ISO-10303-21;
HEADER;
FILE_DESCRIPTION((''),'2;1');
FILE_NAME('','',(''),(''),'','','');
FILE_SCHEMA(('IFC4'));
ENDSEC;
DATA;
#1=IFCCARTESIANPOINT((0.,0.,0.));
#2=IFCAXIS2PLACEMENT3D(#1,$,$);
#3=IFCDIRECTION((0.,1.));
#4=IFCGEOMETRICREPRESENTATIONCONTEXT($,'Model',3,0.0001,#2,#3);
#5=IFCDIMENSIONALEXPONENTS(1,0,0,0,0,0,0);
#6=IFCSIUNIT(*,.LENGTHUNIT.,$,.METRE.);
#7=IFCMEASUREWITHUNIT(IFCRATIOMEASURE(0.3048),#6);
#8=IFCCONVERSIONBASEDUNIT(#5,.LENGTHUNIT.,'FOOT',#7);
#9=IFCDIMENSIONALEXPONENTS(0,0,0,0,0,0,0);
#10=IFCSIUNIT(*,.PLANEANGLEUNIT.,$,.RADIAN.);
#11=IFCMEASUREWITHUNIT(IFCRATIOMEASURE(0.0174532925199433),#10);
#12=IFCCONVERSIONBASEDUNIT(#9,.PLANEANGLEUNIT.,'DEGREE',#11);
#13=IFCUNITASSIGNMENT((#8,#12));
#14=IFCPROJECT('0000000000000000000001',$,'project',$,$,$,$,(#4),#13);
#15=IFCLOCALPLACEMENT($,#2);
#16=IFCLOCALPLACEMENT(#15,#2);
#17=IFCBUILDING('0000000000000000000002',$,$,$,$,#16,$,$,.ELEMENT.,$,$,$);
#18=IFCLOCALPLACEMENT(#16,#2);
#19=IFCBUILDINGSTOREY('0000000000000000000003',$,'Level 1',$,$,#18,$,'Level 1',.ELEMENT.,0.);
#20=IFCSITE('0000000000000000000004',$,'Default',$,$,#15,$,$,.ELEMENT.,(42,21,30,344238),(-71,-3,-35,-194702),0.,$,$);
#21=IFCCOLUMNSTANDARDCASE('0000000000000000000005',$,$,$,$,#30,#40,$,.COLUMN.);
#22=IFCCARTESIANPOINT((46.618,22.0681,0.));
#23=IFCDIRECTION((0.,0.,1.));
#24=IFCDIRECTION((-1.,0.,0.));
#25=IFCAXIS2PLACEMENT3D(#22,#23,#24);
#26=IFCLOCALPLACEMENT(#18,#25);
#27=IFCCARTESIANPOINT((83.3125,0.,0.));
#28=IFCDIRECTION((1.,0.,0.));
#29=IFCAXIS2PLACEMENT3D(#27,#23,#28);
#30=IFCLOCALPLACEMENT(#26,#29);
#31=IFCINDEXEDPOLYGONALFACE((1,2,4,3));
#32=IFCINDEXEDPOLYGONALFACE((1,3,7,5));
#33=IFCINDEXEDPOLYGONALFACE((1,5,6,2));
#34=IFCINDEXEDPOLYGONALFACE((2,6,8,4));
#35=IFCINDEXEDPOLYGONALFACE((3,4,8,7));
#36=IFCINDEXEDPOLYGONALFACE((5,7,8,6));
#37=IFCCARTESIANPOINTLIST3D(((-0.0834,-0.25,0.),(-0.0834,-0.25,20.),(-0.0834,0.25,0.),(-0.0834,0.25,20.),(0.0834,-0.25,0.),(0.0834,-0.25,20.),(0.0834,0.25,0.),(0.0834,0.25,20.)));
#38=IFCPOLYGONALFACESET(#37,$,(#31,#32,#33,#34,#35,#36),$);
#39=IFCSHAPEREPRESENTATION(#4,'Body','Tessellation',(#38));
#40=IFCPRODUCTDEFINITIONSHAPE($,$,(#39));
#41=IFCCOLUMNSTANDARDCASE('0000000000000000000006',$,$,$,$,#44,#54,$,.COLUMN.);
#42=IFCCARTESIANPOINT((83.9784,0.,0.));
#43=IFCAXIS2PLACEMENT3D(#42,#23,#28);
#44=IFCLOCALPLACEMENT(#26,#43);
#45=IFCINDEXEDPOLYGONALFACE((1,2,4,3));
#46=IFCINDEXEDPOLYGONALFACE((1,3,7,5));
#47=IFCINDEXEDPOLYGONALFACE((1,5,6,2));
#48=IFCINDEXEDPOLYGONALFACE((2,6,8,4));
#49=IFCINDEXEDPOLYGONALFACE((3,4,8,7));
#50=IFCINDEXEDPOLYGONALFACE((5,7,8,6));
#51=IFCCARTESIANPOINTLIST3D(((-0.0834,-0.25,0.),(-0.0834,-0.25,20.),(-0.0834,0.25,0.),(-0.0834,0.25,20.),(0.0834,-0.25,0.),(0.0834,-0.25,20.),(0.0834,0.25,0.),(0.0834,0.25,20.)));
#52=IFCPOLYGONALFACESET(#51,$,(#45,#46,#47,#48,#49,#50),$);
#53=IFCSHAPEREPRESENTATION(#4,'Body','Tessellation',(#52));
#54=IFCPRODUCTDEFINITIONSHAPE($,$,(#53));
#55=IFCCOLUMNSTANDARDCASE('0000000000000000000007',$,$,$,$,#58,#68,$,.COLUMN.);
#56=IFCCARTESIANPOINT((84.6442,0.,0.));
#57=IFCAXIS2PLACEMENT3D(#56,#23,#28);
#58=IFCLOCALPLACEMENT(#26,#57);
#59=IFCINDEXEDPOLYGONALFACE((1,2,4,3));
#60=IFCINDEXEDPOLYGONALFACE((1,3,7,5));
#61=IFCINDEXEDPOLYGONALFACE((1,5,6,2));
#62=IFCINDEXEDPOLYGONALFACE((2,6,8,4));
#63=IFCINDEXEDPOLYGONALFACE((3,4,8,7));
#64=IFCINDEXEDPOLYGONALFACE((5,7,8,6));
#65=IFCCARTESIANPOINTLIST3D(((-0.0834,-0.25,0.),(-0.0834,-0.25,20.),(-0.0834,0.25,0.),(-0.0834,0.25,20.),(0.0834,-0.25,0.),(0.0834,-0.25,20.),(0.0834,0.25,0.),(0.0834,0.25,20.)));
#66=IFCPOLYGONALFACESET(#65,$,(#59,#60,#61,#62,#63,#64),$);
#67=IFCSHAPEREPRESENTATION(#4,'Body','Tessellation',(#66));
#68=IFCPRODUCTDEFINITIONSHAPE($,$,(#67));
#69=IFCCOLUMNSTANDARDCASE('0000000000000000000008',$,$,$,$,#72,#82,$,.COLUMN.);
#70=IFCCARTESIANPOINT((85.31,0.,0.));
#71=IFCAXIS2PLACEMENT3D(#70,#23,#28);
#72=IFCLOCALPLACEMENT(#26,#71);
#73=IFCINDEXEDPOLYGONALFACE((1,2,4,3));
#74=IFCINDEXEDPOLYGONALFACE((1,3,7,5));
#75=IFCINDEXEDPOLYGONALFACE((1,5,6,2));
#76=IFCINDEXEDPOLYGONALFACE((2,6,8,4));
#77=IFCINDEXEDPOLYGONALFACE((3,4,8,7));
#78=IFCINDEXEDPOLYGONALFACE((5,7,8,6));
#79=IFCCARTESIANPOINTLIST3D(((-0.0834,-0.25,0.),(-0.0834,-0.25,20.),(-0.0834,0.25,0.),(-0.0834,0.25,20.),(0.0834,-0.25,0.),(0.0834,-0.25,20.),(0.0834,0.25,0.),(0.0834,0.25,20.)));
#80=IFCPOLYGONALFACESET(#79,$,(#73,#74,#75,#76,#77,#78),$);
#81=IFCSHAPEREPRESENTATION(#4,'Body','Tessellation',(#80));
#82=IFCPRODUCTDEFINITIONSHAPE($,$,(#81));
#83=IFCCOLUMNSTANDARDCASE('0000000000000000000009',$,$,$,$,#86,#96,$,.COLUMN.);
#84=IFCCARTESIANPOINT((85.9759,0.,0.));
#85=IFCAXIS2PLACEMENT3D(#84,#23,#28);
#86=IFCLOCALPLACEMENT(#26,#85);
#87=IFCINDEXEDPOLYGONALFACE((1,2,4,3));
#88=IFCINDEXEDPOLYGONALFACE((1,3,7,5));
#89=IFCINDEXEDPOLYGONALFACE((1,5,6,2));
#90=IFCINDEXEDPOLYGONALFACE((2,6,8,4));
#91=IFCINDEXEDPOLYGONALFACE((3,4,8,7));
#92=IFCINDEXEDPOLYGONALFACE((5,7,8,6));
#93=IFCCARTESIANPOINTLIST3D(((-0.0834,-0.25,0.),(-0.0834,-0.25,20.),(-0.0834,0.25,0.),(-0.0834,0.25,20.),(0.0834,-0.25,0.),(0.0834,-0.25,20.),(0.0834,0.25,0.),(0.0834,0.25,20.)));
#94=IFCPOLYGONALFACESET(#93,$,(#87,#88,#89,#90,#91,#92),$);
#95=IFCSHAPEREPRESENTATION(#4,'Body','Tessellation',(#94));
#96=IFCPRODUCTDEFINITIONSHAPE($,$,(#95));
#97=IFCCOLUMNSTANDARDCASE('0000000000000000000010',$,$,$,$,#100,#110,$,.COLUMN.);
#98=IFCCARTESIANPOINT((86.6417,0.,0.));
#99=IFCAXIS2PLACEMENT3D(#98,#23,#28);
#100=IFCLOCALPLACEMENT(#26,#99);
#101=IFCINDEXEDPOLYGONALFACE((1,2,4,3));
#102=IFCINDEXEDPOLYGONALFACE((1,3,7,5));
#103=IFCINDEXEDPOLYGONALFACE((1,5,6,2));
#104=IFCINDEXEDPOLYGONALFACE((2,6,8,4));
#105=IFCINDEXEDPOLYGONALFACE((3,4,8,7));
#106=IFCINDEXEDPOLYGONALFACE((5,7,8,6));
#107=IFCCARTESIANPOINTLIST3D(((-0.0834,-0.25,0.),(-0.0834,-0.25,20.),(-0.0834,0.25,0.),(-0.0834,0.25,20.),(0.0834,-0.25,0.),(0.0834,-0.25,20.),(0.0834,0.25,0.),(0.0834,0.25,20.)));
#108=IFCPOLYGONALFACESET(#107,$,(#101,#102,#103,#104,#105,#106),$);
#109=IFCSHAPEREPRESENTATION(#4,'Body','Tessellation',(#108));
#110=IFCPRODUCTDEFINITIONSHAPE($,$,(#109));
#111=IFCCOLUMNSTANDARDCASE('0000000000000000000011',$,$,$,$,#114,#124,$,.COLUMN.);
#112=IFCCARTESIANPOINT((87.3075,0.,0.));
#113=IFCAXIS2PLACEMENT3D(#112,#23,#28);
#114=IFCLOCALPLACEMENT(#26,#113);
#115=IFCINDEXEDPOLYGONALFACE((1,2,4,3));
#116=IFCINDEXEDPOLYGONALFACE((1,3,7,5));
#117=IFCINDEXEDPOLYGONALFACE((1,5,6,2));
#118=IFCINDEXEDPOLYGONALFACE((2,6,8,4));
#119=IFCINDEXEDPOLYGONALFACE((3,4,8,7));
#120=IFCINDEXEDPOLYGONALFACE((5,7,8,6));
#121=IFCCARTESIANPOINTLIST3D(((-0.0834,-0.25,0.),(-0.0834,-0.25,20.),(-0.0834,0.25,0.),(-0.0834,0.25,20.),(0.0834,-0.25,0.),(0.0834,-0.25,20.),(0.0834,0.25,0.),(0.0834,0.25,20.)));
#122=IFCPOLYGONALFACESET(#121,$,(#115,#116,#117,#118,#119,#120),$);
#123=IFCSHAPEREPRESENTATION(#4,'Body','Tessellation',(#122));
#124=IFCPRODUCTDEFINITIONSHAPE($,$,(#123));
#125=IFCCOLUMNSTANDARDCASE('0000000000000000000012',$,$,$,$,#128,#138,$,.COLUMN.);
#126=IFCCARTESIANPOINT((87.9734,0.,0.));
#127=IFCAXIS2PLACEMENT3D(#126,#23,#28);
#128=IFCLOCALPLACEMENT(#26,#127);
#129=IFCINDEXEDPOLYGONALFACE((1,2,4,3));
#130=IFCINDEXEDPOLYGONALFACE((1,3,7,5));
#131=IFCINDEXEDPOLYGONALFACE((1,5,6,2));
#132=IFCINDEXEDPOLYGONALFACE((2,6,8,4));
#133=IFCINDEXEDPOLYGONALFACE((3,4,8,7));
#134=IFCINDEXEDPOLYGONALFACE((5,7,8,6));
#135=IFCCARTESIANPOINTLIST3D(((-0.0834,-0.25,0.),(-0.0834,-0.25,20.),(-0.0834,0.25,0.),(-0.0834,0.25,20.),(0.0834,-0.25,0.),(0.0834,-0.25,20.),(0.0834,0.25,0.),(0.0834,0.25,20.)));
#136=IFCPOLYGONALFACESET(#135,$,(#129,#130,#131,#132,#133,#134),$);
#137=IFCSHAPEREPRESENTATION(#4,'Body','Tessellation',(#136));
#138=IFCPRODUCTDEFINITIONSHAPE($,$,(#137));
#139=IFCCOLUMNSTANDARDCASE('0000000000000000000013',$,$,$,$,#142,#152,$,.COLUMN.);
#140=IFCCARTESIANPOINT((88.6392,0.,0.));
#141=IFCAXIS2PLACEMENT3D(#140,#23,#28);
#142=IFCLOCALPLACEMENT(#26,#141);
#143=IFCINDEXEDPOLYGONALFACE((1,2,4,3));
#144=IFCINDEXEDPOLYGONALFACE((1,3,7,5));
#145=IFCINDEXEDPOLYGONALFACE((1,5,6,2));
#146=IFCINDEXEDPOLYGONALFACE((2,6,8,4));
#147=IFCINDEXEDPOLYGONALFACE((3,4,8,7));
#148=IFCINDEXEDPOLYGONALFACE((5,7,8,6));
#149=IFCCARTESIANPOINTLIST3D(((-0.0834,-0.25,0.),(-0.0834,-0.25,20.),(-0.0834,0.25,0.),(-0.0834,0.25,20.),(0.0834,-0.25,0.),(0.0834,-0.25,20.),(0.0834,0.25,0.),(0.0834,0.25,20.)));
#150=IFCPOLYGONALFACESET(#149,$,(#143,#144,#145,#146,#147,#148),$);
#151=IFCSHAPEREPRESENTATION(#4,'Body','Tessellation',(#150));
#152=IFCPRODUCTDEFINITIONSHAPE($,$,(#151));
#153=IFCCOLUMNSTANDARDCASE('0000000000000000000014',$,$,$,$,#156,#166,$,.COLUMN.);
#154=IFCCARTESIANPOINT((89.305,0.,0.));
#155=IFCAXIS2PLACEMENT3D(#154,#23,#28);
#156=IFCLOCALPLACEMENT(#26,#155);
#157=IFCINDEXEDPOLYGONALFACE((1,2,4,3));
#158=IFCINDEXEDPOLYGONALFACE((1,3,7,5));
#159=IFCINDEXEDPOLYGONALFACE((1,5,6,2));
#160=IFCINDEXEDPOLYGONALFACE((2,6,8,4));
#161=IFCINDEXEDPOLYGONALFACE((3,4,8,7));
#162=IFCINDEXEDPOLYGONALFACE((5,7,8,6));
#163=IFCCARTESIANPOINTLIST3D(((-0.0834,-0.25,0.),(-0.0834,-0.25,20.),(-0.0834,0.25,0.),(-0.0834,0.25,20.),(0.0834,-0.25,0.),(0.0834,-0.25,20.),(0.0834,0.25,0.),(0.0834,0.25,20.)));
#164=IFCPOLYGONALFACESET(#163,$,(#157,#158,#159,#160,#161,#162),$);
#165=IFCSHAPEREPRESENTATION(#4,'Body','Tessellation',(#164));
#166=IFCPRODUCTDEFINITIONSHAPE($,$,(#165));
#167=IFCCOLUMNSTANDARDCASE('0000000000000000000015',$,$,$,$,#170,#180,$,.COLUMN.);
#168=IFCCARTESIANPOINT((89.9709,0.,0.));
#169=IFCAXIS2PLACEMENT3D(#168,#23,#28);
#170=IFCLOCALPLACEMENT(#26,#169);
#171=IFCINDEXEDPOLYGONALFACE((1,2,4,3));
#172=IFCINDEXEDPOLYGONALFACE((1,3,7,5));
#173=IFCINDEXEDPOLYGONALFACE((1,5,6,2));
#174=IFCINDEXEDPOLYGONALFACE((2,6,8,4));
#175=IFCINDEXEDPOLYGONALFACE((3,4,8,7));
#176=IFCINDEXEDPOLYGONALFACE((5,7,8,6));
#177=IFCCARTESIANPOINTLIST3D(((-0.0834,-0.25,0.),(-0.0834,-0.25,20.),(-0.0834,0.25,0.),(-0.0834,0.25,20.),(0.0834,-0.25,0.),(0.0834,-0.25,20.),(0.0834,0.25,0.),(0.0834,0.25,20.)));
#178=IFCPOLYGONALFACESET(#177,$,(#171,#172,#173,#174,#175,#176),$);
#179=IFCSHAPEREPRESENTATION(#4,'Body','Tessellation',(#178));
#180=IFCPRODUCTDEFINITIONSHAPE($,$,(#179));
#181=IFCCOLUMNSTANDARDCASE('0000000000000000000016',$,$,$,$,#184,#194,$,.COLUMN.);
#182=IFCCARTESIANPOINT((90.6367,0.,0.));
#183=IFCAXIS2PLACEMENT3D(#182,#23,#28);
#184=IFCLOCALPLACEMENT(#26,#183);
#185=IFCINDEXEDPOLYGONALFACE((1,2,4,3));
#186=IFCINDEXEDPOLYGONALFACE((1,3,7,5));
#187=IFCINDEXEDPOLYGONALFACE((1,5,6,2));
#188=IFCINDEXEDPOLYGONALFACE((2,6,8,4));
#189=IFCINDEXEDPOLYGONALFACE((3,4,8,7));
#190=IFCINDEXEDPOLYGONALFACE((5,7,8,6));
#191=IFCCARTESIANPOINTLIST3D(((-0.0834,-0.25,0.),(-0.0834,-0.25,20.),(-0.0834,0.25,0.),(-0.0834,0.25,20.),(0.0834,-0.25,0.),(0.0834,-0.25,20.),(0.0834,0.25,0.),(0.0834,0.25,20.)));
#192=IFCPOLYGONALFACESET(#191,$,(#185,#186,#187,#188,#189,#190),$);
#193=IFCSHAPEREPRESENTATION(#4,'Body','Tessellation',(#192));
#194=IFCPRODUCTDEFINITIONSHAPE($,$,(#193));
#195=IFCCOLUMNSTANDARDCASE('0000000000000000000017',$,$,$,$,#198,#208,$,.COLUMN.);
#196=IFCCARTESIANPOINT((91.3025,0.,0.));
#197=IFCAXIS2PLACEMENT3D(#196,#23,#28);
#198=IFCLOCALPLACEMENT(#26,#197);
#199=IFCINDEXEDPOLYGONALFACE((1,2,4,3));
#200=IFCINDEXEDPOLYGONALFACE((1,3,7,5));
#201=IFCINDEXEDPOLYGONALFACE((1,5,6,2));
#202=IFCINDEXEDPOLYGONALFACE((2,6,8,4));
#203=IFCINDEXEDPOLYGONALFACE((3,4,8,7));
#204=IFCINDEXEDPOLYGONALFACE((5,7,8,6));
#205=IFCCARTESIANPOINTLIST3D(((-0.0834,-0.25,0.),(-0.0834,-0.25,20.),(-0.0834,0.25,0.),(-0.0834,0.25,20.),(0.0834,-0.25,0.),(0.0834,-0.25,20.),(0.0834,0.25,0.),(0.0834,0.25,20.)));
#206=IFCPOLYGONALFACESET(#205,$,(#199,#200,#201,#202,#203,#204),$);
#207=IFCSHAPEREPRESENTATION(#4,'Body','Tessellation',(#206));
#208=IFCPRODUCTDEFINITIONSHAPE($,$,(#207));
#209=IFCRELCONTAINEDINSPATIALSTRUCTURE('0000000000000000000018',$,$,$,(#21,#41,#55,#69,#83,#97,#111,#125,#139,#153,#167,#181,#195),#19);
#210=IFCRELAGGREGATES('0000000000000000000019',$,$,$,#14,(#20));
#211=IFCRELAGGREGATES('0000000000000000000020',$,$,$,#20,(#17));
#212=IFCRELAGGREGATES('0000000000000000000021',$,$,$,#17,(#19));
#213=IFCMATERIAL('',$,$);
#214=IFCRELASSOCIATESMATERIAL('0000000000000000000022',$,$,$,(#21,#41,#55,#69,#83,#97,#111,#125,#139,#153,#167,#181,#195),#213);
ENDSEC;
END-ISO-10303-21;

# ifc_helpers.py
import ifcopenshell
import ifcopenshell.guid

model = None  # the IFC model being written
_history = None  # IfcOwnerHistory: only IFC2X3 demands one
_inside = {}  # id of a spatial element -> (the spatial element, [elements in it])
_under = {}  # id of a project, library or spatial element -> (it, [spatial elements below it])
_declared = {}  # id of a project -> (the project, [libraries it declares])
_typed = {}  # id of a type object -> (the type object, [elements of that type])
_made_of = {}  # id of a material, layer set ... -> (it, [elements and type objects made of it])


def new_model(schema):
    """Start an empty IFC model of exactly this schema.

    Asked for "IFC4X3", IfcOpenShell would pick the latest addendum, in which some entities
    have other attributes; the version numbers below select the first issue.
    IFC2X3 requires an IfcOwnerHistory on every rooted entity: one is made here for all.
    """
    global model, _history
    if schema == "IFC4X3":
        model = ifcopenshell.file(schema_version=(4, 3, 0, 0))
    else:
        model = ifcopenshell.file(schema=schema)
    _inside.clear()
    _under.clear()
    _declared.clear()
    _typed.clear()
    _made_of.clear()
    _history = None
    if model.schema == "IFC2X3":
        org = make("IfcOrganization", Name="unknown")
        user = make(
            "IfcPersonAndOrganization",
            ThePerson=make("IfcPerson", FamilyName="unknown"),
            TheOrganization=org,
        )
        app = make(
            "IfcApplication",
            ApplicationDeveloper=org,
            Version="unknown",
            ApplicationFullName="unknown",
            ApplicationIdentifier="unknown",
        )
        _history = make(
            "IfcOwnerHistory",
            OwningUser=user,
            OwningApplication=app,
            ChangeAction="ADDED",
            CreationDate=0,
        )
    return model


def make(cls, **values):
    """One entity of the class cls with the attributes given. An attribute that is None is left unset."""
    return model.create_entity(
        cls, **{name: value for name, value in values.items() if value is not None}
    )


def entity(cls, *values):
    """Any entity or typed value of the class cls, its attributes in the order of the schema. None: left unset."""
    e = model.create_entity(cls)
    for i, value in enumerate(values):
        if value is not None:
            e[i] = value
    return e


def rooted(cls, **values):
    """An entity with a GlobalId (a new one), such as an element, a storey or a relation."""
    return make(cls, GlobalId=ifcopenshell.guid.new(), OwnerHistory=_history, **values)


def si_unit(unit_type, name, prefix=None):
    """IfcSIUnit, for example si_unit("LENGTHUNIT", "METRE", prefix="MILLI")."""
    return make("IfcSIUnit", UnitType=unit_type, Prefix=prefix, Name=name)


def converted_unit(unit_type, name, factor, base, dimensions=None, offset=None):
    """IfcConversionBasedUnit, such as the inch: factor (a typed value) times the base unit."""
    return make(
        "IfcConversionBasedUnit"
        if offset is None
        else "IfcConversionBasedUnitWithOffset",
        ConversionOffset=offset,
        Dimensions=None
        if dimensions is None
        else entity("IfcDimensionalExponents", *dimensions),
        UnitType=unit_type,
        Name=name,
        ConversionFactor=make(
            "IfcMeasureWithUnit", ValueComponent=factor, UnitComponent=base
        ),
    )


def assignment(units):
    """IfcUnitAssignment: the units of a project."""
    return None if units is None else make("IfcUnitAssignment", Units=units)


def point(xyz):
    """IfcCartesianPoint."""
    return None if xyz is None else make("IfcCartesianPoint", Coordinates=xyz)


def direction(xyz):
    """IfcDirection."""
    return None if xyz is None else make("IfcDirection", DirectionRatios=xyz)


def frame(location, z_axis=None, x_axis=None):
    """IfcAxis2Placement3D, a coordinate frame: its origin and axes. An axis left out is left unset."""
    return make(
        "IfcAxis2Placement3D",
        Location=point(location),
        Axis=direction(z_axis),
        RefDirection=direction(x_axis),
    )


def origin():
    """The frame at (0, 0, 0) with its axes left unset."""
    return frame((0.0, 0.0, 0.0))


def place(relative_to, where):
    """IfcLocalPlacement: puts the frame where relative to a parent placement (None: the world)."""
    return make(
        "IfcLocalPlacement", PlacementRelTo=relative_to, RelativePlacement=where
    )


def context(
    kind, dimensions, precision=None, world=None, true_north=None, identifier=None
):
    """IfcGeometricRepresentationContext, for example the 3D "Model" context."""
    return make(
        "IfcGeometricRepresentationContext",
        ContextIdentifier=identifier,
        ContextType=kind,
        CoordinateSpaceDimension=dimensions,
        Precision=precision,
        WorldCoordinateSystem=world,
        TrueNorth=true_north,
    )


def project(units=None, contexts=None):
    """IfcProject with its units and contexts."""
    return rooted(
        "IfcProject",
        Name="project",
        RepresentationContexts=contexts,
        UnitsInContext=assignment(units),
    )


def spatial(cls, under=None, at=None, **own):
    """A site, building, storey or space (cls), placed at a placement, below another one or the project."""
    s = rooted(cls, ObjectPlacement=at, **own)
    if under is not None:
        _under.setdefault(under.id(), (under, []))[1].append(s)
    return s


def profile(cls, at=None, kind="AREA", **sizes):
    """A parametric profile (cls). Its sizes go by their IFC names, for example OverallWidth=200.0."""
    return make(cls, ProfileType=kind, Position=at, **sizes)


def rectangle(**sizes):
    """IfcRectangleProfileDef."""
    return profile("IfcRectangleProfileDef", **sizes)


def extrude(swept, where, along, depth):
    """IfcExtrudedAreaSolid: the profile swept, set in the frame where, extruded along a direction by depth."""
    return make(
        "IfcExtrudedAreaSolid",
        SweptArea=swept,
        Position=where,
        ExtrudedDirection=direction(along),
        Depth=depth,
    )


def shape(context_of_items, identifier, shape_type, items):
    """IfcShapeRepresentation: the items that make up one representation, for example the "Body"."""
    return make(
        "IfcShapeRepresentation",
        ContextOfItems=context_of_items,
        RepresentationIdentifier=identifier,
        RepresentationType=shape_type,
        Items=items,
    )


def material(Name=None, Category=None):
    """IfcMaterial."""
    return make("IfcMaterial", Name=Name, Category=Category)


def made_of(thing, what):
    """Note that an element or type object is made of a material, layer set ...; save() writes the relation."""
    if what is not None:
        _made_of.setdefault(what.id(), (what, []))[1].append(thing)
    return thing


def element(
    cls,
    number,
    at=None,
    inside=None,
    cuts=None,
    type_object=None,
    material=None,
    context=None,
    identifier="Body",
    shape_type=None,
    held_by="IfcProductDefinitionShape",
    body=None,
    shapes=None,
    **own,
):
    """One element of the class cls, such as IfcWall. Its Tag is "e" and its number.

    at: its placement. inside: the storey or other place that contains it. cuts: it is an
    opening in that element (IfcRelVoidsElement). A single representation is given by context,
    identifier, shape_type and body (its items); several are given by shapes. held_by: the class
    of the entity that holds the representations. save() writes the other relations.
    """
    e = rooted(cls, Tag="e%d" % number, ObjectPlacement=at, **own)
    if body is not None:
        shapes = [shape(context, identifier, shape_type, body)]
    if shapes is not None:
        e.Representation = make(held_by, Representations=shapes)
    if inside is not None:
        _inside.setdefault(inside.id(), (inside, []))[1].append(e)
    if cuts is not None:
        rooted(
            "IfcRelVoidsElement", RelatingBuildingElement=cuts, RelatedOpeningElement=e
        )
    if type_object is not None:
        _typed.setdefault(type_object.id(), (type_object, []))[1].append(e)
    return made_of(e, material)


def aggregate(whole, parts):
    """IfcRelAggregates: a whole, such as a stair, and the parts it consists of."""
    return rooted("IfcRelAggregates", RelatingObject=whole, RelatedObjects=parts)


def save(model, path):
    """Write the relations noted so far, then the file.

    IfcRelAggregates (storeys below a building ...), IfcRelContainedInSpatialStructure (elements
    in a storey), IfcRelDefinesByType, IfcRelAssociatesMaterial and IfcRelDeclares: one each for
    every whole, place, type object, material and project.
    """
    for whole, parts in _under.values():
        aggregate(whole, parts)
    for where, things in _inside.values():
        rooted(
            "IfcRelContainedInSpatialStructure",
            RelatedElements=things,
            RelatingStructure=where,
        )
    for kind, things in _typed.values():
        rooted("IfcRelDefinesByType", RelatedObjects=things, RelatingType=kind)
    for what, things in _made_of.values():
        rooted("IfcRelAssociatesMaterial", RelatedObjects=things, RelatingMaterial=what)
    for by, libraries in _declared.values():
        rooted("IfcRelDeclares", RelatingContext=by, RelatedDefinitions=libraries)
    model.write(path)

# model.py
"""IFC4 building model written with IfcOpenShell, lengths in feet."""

from ifc_helpers import new_model, entity, si_unit, converted_unit, direction, frame, origin, place, context, project, spatial, rectangle, extrude, material, element, save


model = new_model("IFC4")

# Units and contexts
model_context = context("Model", 3, precision=0.0001, world=origin(), true_north=direction((0.0, 1.0)))
ifc_project = project(units=[converted_unit("LENGTHUNIT", "FOOT", entity("IfcRatioMeasure", 0.3048), si_unit("LENGTHUNIT", "METRE"), dimensions=[1, 0, 0, 0, 0, 0, 0]), converted_unit("PLANEANGLEUNIT", "DEGREE", entity("IfcRatioMeasure", 0.0174532925199433), si_unit("PLANEANGLEUNIT", "RADIAN"), dimensions=[0, 0, 0, 0, 0, 0, 0])], contexts=[model_context])

# Site, building, storey
site_placement = place(None, origin())
site = spatial("IfcSite", under=ifc_project, at=site_placement, Name="Default", CompositionType="ELEMENT", RefLatitude=(42, 21, 30, 344238), RefLongitude=(-71, -3, -35, -194702), RefElevation=0.0)
building_placement = place(site_placement, origin())
building = spatial("IfcBuilding", under=site, at=building_placement, CompositionType="ELEMENT")
storey_placement = place(building_placement, origin())
storey = spatial("IfcBuildingStorey", under=building, at=storey_placement, Name="Level 1", LongName="Level 1", CompositionType="ELEMENT", Elevation=0.0)

# Columns
ifc_material = material(Name="")
placement = place(storey_placement, frame((46.618, 22.0681, 0.0), z_axis=(0.0, 0.0, 1.0), x_axis=(-1.0, 0.0, 0.0)))
for number, where, z_axis, x_axis in (
    (1, (83.3125, 0.0, 0.0), (0.0, 0.0, 1.0), (1.0, 0.0, 0.0)),
    (2, (83.9784, 0.0, 0.0), (0.0, 0.0, 1.0), (1.0, 0.0, 0.0)),
    (3, (84.6442, 0.0, 0.0), (0.0, 0.0, 1.0), (1.0, 0.0, 0.0)),
    (4, (85.31, 0.0, 0.0), (0.0, 0.0, 1.0), (1.0, 0.0, 0.0)),
    (5, (85.9759, 0.0, 0.0), (0.0, 0.0, 1.0), (1.0, 0.0, 0.0)),
    (6, (86.6417, 0.0, 0.0), (0.0, 0.0, 1.0), (1.0, 0.0, 0.0)),
    (7, (87.3075, 0.0, 0.0), (0.0, 0.0, 1.0), (1.0, 0.0, 0.0)),
    (8, (87.9734, 0.0, 0.0), (0.0, 0.0, 1.0), (1.0, 0.0, 0.0)),
    (9, (88.6392, 0.0, 0.0), (0.0, 0.0, 1.0), (1.0, 0.0, 0.0)),
    (10, (89.305, 0.0, 0.0), (0.0, 0.0, 1.0), (1.0, 0.0, 0.0)),
    (11, (89.9709, 0.0, 0.0), (0.0, 0.0, 1.0), (1.0, 0.0, 0.0)),
    (12, (90.6367, 0.0, 0.0), (0.0, 0.0, 1.0), (1.0, 0.0, 0.0)),
    (13, (91.3025, 0.0, 0.0), (0.0, 0.0, 1.0), (1.0, 0.0, 0.0)),
):
    element("IfcColumnStandardCase", number, at=place(placement, frame(where, z_axis=z_axis, x_axis=x_axis)), inside=storey, material=ifc_material, PredefinedType="COLUMN", context=model_context, shape_type="SweptSolid", body=[
        extrude(rectangle(XDim=0.1667, YDim=0.5), origin(), (0.0, 0.0, 1.0), 20.0),
    ])

save(model, "model.ifc")
